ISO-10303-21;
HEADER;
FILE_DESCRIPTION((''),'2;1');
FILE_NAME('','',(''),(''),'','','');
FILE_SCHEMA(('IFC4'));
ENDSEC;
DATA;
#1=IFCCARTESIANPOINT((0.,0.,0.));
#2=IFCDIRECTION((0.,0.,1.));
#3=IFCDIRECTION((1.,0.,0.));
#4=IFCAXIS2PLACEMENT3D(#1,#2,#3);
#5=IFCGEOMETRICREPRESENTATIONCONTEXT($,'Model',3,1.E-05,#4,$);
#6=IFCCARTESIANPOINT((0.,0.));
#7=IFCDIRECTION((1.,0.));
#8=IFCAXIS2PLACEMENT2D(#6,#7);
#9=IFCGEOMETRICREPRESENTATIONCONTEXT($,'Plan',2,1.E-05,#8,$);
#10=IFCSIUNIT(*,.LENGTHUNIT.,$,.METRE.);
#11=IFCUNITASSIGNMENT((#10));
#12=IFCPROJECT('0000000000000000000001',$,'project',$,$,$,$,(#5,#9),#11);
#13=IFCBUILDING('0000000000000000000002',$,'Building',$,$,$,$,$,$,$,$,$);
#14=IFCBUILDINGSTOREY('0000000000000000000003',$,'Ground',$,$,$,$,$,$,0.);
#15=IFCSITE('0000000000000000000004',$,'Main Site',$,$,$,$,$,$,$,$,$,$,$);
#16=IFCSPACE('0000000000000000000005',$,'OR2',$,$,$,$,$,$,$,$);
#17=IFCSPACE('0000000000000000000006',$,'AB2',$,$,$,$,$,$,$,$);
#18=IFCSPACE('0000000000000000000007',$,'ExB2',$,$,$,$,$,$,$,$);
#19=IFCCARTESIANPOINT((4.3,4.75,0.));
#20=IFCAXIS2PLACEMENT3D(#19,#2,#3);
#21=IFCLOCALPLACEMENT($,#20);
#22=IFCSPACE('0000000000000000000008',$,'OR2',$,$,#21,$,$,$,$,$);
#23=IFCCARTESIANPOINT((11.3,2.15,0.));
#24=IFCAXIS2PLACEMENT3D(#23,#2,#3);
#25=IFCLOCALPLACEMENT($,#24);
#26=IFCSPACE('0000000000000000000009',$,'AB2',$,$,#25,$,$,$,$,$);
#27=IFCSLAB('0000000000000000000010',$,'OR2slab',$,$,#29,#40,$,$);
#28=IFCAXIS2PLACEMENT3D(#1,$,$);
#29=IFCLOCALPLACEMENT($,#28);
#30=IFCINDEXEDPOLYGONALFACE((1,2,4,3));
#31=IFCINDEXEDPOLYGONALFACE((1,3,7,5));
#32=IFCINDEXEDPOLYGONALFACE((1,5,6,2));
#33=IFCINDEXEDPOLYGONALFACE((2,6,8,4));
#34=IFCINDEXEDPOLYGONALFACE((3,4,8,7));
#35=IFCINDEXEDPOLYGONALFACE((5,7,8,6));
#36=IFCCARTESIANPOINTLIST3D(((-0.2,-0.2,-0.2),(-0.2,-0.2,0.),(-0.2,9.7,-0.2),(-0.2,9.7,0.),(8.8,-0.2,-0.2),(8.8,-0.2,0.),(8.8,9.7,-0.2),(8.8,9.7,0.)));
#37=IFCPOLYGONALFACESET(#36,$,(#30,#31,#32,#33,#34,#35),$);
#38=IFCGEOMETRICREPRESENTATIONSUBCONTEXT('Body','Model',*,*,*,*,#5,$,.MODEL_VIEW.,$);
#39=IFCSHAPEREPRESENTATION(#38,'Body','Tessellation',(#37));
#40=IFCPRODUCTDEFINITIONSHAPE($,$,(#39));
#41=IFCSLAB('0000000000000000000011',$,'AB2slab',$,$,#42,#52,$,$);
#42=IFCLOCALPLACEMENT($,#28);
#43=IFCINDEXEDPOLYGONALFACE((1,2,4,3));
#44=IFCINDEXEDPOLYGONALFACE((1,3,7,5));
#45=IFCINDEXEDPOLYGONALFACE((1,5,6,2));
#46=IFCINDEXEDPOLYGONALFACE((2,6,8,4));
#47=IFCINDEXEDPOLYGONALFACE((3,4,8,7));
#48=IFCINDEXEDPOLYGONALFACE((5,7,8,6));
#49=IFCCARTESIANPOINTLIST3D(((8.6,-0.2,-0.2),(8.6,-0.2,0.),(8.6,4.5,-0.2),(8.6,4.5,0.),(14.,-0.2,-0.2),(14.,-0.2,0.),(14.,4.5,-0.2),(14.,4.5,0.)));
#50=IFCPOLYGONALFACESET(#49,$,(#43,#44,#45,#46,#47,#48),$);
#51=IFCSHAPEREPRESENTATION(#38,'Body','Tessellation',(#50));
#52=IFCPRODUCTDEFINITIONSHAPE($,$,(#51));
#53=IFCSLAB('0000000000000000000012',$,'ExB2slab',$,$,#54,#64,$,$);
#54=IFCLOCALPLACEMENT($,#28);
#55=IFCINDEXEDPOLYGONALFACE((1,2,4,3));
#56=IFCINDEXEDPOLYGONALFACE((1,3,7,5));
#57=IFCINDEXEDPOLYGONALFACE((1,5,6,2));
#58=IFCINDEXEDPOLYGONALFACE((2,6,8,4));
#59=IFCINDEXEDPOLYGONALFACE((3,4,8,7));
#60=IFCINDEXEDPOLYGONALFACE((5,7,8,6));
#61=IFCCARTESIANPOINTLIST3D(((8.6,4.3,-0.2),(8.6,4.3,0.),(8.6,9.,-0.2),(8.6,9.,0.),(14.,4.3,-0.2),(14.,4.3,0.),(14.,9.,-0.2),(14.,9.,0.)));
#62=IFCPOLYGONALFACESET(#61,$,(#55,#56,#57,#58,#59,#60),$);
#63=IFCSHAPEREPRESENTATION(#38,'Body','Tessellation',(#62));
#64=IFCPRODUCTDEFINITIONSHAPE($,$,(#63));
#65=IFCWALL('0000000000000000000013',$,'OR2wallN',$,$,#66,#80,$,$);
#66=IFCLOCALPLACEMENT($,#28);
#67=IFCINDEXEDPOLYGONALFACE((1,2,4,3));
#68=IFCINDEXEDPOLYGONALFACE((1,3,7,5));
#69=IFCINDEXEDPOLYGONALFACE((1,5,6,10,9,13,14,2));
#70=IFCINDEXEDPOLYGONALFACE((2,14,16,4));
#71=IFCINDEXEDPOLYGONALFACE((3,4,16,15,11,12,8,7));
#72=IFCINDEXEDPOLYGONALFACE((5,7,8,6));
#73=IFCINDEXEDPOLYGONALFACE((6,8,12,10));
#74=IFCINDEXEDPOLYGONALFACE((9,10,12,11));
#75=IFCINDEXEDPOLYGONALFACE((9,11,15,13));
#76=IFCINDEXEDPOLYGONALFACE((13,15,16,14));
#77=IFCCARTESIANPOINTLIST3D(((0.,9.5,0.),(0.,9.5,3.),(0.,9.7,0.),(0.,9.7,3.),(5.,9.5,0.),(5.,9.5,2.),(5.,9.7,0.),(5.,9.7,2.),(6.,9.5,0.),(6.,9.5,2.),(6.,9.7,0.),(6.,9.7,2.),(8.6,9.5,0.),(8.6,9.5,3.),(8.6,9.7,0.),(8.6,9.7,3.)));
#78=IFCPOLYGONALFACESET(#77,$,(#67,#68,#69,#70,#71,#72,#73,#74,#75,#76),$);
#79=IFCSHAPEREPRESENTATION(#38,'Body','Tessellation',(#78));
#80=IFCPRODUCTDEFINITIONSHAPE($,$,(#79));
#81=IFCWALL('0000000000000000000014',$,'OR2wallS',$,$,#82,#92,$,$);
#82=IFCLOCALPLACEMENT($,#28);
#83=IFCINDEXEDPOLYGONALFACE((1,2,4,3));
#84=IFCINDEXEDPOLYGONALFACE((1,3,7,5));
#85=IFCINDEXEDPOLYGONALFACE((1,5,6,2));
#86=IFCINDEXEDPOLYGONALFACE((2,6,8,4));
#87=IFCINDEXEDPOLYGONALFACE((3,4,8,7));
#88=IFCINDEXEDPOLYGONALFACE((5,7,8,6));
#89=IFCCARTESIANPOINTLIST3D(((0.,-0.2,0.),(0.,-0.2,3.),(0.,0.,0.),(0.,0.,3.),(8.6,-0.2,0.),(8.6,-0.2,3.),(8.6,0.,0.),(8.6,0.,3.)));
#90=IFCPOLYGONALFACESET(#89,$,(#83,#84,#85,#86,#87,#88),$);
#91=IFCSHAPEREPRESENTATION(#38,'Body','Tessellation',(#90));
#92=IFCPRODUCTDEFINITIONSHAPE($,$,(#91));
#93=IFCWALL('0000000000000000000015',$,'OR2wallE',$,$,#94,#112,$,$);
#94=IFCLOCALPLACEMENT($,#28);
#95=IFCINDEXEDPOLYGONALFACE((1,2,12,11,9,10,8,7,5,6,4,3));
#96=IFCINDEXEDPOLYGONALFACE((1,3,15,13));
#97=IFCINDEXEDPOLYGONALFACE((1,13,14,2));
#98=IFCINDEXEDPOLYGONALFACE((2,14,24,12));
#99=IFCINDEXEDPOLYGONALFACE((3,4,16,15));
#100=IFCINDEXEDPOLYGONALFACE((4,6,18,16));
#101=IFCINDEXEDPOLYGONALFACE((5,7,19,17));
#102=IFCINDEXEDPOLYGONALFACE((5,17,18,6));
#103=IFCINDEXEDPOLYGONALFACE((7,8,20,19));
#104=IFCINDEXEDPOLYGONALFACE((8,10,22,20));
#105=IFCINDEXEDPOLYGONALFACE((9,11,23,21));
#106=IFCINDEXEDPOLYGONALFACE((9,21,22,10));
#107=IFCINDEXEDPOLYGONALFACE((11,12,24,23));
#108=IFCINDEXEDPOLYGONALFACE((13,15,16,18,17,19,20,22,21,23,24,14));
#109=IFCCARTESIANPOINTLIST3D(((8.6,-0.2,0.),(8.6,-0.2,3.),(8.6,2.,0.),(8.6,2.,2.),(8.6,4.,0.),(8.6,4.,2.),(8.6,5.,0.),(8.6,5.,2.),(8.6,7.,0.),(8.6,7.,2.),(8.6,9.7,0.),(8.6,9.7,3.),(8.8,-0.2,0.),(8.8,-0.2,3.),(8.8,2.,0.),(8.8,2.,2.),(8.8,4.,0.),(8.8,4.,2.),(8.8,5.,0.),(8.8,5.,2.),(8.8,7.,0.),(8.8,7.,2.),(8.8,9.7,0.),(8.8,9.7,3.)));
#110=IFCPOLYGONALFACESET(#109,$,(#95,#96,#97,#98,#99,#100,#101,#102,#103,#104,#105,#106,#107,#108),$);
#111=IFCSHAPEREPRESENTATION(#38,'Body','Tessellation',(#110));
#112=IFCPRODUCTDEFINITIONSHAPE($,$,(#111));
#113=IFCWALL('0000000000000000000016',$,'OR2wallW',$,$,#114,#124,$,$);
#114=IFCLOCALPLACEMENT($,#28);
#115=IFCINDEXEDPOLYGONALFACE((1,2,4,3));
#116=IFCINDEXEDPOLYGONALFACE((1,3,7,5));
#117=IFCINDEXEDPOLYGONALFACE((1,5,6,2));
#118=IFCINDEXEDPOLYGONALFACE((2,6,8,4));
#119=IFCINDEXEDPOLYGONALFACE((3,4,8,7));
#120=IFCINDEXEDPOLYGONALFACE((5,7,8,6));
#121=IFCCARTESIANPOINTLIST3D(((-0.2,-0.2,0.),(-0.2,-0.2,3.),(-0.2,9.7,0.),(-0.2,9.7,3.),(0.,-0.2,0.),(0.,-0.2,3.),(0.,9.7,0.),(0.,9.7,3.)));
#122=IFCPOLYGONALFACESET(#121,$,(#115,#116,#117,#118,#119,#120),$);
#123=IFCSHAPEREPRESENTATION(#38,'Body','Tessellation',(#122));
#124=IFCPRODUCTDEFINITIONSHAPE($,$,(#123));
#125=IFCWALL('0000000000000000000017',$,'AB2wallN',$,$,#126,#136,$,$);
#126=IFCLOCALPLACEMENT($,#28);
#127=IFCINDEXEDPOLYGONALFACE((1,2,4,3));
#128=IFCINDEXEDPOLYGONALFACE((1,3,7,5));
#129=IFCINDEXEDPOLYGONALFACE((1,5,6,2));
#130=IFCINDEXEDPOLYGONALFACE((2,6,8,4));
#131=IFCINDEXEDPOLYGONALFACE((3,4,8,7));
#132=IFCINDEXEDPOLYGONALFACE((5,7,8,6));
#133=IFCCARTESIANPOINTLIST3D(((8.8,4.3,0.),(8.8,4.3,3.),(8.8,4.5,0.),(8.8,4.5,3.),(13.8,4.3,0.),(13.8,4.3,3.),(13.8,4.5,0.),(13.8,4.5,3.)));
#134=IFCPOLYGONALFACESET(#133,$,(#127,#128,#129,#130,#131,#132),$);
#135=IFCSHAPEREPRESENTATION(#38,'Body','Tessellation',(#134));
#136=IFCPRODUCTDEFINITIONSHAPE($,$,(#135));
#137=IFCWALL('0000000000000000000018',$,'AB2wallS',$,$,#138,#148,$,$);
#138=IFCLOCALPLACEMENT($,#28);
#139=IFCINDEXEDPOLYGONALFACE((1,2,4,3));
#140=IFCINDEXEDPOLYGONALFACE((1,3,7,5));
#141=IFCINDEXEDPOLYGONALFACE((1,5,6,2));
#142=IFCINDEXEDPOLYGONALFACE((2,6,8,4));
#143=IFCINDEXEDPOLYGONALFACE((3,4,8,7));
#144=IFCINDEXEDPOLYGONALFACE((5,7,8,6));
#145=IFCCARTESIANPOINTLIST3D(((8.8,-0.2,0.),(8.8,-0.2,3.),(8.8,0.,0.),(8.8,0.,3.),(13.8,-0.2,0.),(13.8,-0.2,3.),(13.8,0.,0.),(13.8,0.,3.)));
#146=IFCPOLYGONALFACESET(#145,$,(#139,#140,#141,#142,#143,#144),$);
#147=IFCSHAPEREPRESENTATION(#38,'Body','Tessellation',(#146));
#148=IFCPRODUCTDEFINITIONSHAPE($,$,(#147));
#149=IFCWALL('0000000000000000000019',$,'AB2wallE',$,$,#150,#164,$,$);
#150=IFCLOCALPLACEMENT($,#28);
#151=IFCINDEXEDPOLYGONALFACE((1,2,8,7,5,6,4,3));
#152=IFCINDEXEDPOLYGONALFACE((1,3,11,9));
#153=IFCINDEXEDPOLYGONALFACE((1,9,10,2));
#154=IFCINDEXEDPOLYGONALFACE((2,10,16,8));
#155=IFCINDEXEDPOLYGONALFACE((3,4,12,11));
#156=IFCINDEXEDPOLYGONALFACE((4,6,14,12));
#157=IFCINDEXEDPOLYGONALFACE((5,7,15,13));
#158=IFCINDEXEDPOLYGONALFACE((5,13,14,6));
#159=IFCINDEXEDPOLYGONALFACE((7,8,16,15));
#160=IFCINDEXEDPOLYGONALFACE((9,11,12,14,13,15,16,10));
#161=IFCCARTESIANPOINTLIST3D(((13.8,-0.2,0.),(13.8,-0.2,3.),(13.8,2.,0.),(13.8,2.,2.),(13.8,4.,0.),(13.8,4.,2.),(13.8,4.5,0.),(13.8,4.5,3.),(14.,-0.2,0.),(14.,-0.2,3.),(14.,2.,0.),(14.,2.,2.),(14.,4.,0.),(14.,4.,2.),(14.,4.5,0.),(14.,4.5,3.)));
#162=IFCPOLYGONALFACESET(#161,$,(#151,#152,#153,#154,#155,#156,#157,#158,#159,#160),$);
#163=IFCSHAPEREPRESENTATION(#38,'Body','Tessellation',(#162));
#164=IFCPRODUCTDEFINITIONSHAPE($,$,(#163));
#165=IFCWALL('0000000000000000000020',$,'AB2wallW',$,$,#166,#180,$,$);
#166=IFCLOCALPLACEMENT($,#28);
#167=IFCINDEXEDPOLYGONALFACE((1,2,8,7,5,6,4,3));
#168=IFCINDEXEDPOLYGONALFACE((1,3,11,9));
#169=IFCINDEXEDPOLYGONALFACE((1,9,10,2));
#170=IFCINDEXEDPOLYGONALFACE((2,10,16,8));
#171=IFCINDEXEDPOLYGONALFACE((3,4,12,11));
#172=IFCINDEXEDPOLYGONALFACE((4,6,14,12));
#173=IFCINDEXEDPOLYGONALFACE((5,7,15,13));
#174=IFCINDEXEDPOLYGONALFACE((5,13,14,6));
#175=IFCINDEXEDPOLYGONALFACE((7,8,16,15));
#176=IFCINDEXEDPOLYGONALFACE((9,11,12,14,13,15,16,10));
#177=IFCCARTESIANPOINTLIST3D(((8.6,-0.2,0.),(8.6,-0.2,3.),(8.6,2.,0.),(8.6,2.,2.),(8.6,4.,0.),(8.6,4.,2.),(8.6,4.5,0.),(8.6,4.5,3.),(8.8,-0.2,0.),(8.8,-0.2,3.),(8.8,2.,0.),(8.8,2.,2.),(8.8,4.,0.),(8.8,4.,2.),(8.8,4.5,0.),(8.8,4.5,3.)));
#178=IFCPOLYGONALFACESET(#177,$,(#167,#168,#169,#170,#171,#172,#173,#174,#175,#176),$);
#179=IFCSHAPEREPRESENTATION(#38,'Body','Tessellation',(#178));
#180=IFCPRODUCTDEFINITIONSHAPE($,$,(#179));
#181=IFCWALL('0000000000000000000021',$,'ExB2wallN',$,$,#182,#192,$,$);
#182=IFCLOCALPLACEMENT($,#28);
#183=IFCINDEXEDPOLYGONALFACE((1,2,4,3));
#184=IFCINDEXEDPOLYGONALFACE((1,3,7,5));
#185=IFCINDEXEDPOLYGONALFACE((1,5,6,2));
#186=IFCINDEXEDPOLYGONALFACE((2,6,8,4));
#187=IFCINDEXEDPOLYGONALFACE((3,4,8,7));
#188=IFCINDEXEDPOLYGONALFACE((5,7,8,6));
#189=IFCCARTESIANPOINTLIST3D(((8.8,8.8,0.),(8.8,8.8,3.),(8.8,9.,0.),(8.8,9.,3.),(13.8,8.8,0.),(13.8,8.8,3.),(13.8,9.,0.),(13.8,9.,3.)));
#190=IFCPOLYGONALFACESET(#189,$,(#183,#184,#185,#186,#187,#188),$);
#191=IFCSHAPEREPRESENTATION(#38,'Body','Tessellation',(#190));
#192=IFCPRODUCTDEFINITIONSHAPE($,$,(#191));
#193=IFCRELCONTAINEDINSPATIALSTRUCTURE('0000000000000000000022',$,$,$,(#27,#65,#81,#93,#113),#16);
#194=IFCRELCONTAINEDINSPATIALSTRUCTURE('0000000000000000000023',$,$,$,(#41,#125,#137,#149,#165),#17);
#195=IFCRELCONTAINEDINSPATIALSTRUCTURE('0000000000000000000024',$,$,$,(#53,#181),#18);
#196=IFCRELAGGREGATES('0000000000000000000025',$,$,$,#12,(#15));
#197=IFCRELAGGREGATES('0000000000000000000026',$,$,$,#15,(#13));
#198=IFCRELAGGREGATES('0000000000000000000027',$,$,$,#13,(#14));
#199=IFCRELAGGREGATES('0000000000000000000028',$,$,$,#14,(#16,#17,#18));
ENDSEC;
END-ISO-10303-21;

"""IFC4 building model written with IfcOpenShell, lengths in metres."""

from ifc_helpers import new_model, si_unit, frame, origin_with_axes, origin_2d_with_axis, place, context, subcontext, project, spatial, indexed_curve, rectangle, outline, extrude, element, save


model = new_model("IFC4")

# Units and contexts
model_context = context("Model", 3, precision=1e-05, world=origin_with_axes())
plan_context = context("Plan", 2, precision=1e-05, world=origin_2d_with_axis())
body_context = subcontext(model_context, "Body", "Model", "MODEL_VIEW")
ifc_project = project(units=[si_unit("LENGTHUNIT", "METRE")], contexts=[model_context, plan_context])

# Site, building, storey, space
site = spatial("IfcSite", under=ifc_project, Name="Main Site")
building = spatial("IfcBuilding", under=site, Name="Building")
storey = spatial("IfcBuildingStorey", under=building, Name="Ground", Elevation=0.0)
space_1 = spatial("IfcSpace", under=storey, Name="OR2")

# Slab
slab_1_placement = place(None, frame((4.3, 4.75, -0.2), z_axis=(0.0, 0.0, 1.0), x_axis=(1.0, 0.0, 0.0)))
element("IfcSlab", 1, at=slab_1_placement, inside=space_1, Name="OR2slab", context=body_context, shape_type="SweptSolid", body=[
    extrude(rectangle(XDim=9.0, YDim=9.9), origin_with_axes(), (0.0, 0.0, 1.0), 0.2),
])

# Shared definitions
space_2 = spatial("IfcSpace", under=storey, Name="AB2")

# Slab
slab_2_placement = place(None, frame((11.3, 2.15, -0.2), z_axis=(0.0, 0.0, 1.0), x_axis=(1.0, 0.0, 0.0)))
element("IfcSlab", 2, at=slab_2_placement, inside=space_2, Name="AB2slab", context=body_context, shape_type="SweptSolid", body=[
    extrude(rectangle(XDim=5.4, YDim=4.7), origin_with_axes(), (0.0, 0.0, 1.0), 0.2),
])

# Shared definitions
space_3 = spatial("IfcSpace", under=storey, Name="ExB2")

# Slab
slab_3_placement = place(None, frame((11.3, 6.65, -0.2), z_axis=(0.0, 0.0, 1.0), x_axis=(1.0, 0.0, 0.0)))
element("IfcSlab", 3, at=slab_3_placement, inside=space_3, Name="ExB2slab", context=body_context, shape_type="SweptSolid", body=[
    extrude(rectangle(XDim=5.4, YDim=4.7), origin_with_axes(), (0.0, 0.0, 1.0), 0.2),
])

# Wall
wall_1_placement = place(None, frame((0.0, 9.5, 0.0), z_axis=(0.0, 0.0, 1.0), x_axis=(1.0, 0.0, 0.0)))
wall_1 = element("IfcWall", 4, at=wall_1_placement, inside=space_1, Name="OR2wallN", context=body_context, shape_type="SweptSolid", body=[
    extrude(outline(indexed_curve([(0.0, 0.0), (0.0, 0.2), (8.6, 0.2), (8.6, 0.0), (0.0, 0.0)], self_intersect=False)), origin_with_axes(), (0.0, 0.0, 1.0), 3.0),
])

# Shared definitions
space_4_placement = place(None, frame((4.3, 4.75, 0.0), z_axis=(0.0, 0.0, 1.0), x_axis=(1.0, 0.0, 0.0)))
space_4 = spatial("IfcSpace", at=space_4_placement, Name="OR2")

# Opening
opening_1_placement = place(wall_1_placement, frame((5.0, 0.0, 0.0), z_axis=(0.0, 0.0, 1.0), x_axis=(1.0, 0.0, 0.0)))
element("IfcOpeningElement", 5, at=opening_1_placement, inside=space_4, cuts=wall_1, context=body_context, shape_type="SweptSolid", body=[
    extrude(outline(indexed_curve([(0.0, 0.0), (0.0, 0.4), (1.0, 0.4), (1.0, 0.0), (0.0, 0.0)], self_intersect=False)), origin_with_axes(), (0.0, 0.0, 1.0), 2.0),
])

# Wall
wall_2_placement = place(None, frame((0.0, -0.2, 0.0), z_axis=(0.0, 0.0, 1.0), x_axis=(1.0, 0.0, 0.0)))
element("IfcWall", 6, at=wall_2_placement, inside=space_1, Name="OR2wallS", context=body_context, shape_type="SweptSolid", body=[
    extrude(outline(indexed_curve([(0.0, 0.0), (0.0, 0.2), (8.6, 0.2), (8.6, 0.0), (0.0, 0.0)], self_intersect=False)), origin_with_axes(), (0.0, 0.0, 1.0), 3.0),
])

# Wall, openings
wall_3_placement = place(None, frame((8.8, -0.2, 0.0), z_axis=(0.0, 0.0, 1.0), x_axis=(0.0, 1.0, 0.0)))
wall_3 = element("IfcWall", 7, at=wall_3_placement, inside=space_1, Name="OR2wallE", context=body_context, shape_type="SweptSolid", body=[
    extrude(outline(indexed_curve([(0.0, 0.0), (0.0, 0.2), (9.9, 0.2), (9.9, 0.0), (0.0, 0.0)], self_intersect=False)), origin_with_axes(), (0.0, 0.0, 1.0), 3.0),
])
opening_2_placement = place(wall_3_placement, frame((2.2, 0.0, 0.0), z_axis=(0.0, 0.0, 1.0), x_axis=(1.0, 0.0, 0.0)))
element("IfcOpeningElement", 8, at=opening_2_placement, inside=space_4, cuts=wall_3, context=body_context, shape_type="SweptSolid", body=[
    extrude(outline(indexed_curve([(0.0, 0.0), (0.0, 0.4), (2.0, 0.4), (2.0, 0.0), (0.0, 0.0)], self_intersect=False)), origin_with_axes(), (0.0, 0.0, 1.0), 2.0),
])
opening_3_placement = place(wall_3_placement, frame((5.2, 0.0, 0.0), z_axis=(0.0, 0.0, 1.0), x_axis=(1.0, 0.0, 0.0)))
element("IfcOpeningElement", 9, at=opening_3_placement, inside=space_4, cuts=wall_3, context=body_context, shape_type="SweptSolid", body=[
    extrude(outline(indexed_curve([(0.0, 0.0), (0.0, 0.4), (2.0, 0.4), (2.0, 0.0), (0.0, 0.0)], self_intersect=False)), origin_with_axes(), (0.0, 0.0, 1.0), 2.0),
])

# Walls
wall_4_placement = place(None, frame((0.0, -0.2, 0.0), z_axis=(0.0, 0.0, 1.0), x_axis=(0.0, 1.0, 0.0)))
element("IfcWall", 10, at=wall_4_placement, inside=space_1, Name="OR2wallW", context=body_context, shape_type="SweptSolid", body=[
    extrude(outline(indexed_curve([(0.0, 0.0), (0.0, 0.2), (9.9, 0.2), (9.9, 0.0), (0.0, 0.0)], self_intersect=False)), origin_with_axes(), (0.0, 0.0, 1.0), 3.0),
])
for number, where, z_axis, x_axis, name in (
    (11, (8.8, 4.3, 0.0), (0.0, 0.0, 1.0), (1.0, 0.0, 0.0), "AB2wallN"),
    (12, (8.8, -0.2, 0.0), (0.0, 0.0, 1.0), (1.0, 0.0, 0.0), "AB2wallS"),
):
    element("IfcWall", number, at=place(None, frame(where, z_axis=z_axis, x_axis=x_axis)), inside=space_2, Name=name, context=body_context, shape_type="SweptSolid", body=[
        extrude(outline(indexed_curve([(0.0, 0.0), (0.0, 0.2), (5.0, 0.2), (5.0, 0.0), (0.0, 0.0)], self_intersect=False)), origin_with_axes(), (0.0, 0.0, 1.0), 3.0),
    ])

# Wall
wall_5_placement = place(None, frame((14.0, -0.2, 0.0), z_axis=(0.0, 0.0, 1.0), x_axis=(0.0, 1.0, 0.0)))
wall_5 = element("IfcWall", 13, at=wall_5_placement, inside=space_2, Name="AB2wallE", context=body_context, shape_type="SweptSolid", body=[
    extrude(outline(indexed_curve([(0.0, 0.0), (0.0, 0.2), (4.7, 0.2), (4.7, 0.0), (0.0, 0.0)], self_intersect=False)), origin_with_axes(), (0.0, 0.0, 1.0), 3.0),
])

# Shared definitions
space_5_placement = place(None, frame((11.3, 2.15, 0.0), z_axis=(0.0, 0.0, 1.0), x_axis=(1.0, 0.0, 0.0)))
space_5 = spatial("IfcSpace", at=space_5_placement, Name="AB2")

# Opening
opening_4_placement = place(wall_5_placement, frame((2.2, 0.0, 0.0), z_axis=(0.0, 0.0, 1.0), x_axis=(1.0, 0.0, 0.0)))
element("IfcOpeningElement", 14, at=opening_4_placement, inside=space_5, cuts=wall_5, context=body_context, shape_type="SweptSolid", body=[
    extrude(outline(indexed_curve([(0.0, 0.0), (0.0, 0.4), (2.0, 0.4), (2.0, 0.0), (0.0, 0.0)], self_intersect=False)), origin_with_axes(), (0.0, 0.0, 1.0), 2.0),
])

# Wall, opening
wall_6_placement = place(None, frame((8.8, -0.2, 0.0), z_axis=(0.0, 0.0, 1.0), x_axis=(0.0, 1.0, 0.0)))
wall_6 = element("IfcWall", 15, at=wall_6_placement, inside=space_2, Name="AB2wallW", context=body_context, shape_type="SweptSolid", body=[
    extrude(outline(indexed_curve([(0.0, 0.0), (0.0, 0.2), (4.7, 0.2), (4.7, 0.0), (0.0, 0.0)], self_intersect=False)), origin_with_axes(), (0.0, 0.0, 1.0), 3.0),
])
opening_5_placement = place(wall_6_placement, frame((2.2, 0.0, 0.0), z_axis=(0.0, 0.0, 1.0), x_axis=(1.0, 0.0, 0.0)))
element("IfcOpeningElement", 16, at=opening_5_placement, inside=space_5, cuts=wall_6, context=body_context, shape_type="SweptSolid", body=[
    extrude(outline(indexed_curve([(0.0, 0.0), (0.0, 0.4), (2.0, 0.4), (2.0, 0.0), (0.0, 0.0)], self_intersect=False)), origin_with_axes(), (0.0, 0.0, 1.0), 2.0),
])

# Wall
for number, where, z_axis, x_axis, name in (
    (17, (8.8, 8.8, 0.0), (0.0, 0.0, 1.0), (1.0, 0.0, 0.0), "ExB2wallN"),
):
    element("IfcWall", number, at=place(None, frame(where, z_axis=z_axis, x_axis=x_axis)), inside=space_3, Name=name, context=body_context, shape_type="SweptSolid", body=[
        extrude(outline(indexed_curve([(0.0, 0.0), (0.0, 0.2), (5.0, 0.2), (5.0, 0.0), (0.0, 0.0)], self_intersect=False)), origin_with_axes(), (0.0, 0.0, 1.0), 3.0),
    ])

save(model, "model.ifc")
